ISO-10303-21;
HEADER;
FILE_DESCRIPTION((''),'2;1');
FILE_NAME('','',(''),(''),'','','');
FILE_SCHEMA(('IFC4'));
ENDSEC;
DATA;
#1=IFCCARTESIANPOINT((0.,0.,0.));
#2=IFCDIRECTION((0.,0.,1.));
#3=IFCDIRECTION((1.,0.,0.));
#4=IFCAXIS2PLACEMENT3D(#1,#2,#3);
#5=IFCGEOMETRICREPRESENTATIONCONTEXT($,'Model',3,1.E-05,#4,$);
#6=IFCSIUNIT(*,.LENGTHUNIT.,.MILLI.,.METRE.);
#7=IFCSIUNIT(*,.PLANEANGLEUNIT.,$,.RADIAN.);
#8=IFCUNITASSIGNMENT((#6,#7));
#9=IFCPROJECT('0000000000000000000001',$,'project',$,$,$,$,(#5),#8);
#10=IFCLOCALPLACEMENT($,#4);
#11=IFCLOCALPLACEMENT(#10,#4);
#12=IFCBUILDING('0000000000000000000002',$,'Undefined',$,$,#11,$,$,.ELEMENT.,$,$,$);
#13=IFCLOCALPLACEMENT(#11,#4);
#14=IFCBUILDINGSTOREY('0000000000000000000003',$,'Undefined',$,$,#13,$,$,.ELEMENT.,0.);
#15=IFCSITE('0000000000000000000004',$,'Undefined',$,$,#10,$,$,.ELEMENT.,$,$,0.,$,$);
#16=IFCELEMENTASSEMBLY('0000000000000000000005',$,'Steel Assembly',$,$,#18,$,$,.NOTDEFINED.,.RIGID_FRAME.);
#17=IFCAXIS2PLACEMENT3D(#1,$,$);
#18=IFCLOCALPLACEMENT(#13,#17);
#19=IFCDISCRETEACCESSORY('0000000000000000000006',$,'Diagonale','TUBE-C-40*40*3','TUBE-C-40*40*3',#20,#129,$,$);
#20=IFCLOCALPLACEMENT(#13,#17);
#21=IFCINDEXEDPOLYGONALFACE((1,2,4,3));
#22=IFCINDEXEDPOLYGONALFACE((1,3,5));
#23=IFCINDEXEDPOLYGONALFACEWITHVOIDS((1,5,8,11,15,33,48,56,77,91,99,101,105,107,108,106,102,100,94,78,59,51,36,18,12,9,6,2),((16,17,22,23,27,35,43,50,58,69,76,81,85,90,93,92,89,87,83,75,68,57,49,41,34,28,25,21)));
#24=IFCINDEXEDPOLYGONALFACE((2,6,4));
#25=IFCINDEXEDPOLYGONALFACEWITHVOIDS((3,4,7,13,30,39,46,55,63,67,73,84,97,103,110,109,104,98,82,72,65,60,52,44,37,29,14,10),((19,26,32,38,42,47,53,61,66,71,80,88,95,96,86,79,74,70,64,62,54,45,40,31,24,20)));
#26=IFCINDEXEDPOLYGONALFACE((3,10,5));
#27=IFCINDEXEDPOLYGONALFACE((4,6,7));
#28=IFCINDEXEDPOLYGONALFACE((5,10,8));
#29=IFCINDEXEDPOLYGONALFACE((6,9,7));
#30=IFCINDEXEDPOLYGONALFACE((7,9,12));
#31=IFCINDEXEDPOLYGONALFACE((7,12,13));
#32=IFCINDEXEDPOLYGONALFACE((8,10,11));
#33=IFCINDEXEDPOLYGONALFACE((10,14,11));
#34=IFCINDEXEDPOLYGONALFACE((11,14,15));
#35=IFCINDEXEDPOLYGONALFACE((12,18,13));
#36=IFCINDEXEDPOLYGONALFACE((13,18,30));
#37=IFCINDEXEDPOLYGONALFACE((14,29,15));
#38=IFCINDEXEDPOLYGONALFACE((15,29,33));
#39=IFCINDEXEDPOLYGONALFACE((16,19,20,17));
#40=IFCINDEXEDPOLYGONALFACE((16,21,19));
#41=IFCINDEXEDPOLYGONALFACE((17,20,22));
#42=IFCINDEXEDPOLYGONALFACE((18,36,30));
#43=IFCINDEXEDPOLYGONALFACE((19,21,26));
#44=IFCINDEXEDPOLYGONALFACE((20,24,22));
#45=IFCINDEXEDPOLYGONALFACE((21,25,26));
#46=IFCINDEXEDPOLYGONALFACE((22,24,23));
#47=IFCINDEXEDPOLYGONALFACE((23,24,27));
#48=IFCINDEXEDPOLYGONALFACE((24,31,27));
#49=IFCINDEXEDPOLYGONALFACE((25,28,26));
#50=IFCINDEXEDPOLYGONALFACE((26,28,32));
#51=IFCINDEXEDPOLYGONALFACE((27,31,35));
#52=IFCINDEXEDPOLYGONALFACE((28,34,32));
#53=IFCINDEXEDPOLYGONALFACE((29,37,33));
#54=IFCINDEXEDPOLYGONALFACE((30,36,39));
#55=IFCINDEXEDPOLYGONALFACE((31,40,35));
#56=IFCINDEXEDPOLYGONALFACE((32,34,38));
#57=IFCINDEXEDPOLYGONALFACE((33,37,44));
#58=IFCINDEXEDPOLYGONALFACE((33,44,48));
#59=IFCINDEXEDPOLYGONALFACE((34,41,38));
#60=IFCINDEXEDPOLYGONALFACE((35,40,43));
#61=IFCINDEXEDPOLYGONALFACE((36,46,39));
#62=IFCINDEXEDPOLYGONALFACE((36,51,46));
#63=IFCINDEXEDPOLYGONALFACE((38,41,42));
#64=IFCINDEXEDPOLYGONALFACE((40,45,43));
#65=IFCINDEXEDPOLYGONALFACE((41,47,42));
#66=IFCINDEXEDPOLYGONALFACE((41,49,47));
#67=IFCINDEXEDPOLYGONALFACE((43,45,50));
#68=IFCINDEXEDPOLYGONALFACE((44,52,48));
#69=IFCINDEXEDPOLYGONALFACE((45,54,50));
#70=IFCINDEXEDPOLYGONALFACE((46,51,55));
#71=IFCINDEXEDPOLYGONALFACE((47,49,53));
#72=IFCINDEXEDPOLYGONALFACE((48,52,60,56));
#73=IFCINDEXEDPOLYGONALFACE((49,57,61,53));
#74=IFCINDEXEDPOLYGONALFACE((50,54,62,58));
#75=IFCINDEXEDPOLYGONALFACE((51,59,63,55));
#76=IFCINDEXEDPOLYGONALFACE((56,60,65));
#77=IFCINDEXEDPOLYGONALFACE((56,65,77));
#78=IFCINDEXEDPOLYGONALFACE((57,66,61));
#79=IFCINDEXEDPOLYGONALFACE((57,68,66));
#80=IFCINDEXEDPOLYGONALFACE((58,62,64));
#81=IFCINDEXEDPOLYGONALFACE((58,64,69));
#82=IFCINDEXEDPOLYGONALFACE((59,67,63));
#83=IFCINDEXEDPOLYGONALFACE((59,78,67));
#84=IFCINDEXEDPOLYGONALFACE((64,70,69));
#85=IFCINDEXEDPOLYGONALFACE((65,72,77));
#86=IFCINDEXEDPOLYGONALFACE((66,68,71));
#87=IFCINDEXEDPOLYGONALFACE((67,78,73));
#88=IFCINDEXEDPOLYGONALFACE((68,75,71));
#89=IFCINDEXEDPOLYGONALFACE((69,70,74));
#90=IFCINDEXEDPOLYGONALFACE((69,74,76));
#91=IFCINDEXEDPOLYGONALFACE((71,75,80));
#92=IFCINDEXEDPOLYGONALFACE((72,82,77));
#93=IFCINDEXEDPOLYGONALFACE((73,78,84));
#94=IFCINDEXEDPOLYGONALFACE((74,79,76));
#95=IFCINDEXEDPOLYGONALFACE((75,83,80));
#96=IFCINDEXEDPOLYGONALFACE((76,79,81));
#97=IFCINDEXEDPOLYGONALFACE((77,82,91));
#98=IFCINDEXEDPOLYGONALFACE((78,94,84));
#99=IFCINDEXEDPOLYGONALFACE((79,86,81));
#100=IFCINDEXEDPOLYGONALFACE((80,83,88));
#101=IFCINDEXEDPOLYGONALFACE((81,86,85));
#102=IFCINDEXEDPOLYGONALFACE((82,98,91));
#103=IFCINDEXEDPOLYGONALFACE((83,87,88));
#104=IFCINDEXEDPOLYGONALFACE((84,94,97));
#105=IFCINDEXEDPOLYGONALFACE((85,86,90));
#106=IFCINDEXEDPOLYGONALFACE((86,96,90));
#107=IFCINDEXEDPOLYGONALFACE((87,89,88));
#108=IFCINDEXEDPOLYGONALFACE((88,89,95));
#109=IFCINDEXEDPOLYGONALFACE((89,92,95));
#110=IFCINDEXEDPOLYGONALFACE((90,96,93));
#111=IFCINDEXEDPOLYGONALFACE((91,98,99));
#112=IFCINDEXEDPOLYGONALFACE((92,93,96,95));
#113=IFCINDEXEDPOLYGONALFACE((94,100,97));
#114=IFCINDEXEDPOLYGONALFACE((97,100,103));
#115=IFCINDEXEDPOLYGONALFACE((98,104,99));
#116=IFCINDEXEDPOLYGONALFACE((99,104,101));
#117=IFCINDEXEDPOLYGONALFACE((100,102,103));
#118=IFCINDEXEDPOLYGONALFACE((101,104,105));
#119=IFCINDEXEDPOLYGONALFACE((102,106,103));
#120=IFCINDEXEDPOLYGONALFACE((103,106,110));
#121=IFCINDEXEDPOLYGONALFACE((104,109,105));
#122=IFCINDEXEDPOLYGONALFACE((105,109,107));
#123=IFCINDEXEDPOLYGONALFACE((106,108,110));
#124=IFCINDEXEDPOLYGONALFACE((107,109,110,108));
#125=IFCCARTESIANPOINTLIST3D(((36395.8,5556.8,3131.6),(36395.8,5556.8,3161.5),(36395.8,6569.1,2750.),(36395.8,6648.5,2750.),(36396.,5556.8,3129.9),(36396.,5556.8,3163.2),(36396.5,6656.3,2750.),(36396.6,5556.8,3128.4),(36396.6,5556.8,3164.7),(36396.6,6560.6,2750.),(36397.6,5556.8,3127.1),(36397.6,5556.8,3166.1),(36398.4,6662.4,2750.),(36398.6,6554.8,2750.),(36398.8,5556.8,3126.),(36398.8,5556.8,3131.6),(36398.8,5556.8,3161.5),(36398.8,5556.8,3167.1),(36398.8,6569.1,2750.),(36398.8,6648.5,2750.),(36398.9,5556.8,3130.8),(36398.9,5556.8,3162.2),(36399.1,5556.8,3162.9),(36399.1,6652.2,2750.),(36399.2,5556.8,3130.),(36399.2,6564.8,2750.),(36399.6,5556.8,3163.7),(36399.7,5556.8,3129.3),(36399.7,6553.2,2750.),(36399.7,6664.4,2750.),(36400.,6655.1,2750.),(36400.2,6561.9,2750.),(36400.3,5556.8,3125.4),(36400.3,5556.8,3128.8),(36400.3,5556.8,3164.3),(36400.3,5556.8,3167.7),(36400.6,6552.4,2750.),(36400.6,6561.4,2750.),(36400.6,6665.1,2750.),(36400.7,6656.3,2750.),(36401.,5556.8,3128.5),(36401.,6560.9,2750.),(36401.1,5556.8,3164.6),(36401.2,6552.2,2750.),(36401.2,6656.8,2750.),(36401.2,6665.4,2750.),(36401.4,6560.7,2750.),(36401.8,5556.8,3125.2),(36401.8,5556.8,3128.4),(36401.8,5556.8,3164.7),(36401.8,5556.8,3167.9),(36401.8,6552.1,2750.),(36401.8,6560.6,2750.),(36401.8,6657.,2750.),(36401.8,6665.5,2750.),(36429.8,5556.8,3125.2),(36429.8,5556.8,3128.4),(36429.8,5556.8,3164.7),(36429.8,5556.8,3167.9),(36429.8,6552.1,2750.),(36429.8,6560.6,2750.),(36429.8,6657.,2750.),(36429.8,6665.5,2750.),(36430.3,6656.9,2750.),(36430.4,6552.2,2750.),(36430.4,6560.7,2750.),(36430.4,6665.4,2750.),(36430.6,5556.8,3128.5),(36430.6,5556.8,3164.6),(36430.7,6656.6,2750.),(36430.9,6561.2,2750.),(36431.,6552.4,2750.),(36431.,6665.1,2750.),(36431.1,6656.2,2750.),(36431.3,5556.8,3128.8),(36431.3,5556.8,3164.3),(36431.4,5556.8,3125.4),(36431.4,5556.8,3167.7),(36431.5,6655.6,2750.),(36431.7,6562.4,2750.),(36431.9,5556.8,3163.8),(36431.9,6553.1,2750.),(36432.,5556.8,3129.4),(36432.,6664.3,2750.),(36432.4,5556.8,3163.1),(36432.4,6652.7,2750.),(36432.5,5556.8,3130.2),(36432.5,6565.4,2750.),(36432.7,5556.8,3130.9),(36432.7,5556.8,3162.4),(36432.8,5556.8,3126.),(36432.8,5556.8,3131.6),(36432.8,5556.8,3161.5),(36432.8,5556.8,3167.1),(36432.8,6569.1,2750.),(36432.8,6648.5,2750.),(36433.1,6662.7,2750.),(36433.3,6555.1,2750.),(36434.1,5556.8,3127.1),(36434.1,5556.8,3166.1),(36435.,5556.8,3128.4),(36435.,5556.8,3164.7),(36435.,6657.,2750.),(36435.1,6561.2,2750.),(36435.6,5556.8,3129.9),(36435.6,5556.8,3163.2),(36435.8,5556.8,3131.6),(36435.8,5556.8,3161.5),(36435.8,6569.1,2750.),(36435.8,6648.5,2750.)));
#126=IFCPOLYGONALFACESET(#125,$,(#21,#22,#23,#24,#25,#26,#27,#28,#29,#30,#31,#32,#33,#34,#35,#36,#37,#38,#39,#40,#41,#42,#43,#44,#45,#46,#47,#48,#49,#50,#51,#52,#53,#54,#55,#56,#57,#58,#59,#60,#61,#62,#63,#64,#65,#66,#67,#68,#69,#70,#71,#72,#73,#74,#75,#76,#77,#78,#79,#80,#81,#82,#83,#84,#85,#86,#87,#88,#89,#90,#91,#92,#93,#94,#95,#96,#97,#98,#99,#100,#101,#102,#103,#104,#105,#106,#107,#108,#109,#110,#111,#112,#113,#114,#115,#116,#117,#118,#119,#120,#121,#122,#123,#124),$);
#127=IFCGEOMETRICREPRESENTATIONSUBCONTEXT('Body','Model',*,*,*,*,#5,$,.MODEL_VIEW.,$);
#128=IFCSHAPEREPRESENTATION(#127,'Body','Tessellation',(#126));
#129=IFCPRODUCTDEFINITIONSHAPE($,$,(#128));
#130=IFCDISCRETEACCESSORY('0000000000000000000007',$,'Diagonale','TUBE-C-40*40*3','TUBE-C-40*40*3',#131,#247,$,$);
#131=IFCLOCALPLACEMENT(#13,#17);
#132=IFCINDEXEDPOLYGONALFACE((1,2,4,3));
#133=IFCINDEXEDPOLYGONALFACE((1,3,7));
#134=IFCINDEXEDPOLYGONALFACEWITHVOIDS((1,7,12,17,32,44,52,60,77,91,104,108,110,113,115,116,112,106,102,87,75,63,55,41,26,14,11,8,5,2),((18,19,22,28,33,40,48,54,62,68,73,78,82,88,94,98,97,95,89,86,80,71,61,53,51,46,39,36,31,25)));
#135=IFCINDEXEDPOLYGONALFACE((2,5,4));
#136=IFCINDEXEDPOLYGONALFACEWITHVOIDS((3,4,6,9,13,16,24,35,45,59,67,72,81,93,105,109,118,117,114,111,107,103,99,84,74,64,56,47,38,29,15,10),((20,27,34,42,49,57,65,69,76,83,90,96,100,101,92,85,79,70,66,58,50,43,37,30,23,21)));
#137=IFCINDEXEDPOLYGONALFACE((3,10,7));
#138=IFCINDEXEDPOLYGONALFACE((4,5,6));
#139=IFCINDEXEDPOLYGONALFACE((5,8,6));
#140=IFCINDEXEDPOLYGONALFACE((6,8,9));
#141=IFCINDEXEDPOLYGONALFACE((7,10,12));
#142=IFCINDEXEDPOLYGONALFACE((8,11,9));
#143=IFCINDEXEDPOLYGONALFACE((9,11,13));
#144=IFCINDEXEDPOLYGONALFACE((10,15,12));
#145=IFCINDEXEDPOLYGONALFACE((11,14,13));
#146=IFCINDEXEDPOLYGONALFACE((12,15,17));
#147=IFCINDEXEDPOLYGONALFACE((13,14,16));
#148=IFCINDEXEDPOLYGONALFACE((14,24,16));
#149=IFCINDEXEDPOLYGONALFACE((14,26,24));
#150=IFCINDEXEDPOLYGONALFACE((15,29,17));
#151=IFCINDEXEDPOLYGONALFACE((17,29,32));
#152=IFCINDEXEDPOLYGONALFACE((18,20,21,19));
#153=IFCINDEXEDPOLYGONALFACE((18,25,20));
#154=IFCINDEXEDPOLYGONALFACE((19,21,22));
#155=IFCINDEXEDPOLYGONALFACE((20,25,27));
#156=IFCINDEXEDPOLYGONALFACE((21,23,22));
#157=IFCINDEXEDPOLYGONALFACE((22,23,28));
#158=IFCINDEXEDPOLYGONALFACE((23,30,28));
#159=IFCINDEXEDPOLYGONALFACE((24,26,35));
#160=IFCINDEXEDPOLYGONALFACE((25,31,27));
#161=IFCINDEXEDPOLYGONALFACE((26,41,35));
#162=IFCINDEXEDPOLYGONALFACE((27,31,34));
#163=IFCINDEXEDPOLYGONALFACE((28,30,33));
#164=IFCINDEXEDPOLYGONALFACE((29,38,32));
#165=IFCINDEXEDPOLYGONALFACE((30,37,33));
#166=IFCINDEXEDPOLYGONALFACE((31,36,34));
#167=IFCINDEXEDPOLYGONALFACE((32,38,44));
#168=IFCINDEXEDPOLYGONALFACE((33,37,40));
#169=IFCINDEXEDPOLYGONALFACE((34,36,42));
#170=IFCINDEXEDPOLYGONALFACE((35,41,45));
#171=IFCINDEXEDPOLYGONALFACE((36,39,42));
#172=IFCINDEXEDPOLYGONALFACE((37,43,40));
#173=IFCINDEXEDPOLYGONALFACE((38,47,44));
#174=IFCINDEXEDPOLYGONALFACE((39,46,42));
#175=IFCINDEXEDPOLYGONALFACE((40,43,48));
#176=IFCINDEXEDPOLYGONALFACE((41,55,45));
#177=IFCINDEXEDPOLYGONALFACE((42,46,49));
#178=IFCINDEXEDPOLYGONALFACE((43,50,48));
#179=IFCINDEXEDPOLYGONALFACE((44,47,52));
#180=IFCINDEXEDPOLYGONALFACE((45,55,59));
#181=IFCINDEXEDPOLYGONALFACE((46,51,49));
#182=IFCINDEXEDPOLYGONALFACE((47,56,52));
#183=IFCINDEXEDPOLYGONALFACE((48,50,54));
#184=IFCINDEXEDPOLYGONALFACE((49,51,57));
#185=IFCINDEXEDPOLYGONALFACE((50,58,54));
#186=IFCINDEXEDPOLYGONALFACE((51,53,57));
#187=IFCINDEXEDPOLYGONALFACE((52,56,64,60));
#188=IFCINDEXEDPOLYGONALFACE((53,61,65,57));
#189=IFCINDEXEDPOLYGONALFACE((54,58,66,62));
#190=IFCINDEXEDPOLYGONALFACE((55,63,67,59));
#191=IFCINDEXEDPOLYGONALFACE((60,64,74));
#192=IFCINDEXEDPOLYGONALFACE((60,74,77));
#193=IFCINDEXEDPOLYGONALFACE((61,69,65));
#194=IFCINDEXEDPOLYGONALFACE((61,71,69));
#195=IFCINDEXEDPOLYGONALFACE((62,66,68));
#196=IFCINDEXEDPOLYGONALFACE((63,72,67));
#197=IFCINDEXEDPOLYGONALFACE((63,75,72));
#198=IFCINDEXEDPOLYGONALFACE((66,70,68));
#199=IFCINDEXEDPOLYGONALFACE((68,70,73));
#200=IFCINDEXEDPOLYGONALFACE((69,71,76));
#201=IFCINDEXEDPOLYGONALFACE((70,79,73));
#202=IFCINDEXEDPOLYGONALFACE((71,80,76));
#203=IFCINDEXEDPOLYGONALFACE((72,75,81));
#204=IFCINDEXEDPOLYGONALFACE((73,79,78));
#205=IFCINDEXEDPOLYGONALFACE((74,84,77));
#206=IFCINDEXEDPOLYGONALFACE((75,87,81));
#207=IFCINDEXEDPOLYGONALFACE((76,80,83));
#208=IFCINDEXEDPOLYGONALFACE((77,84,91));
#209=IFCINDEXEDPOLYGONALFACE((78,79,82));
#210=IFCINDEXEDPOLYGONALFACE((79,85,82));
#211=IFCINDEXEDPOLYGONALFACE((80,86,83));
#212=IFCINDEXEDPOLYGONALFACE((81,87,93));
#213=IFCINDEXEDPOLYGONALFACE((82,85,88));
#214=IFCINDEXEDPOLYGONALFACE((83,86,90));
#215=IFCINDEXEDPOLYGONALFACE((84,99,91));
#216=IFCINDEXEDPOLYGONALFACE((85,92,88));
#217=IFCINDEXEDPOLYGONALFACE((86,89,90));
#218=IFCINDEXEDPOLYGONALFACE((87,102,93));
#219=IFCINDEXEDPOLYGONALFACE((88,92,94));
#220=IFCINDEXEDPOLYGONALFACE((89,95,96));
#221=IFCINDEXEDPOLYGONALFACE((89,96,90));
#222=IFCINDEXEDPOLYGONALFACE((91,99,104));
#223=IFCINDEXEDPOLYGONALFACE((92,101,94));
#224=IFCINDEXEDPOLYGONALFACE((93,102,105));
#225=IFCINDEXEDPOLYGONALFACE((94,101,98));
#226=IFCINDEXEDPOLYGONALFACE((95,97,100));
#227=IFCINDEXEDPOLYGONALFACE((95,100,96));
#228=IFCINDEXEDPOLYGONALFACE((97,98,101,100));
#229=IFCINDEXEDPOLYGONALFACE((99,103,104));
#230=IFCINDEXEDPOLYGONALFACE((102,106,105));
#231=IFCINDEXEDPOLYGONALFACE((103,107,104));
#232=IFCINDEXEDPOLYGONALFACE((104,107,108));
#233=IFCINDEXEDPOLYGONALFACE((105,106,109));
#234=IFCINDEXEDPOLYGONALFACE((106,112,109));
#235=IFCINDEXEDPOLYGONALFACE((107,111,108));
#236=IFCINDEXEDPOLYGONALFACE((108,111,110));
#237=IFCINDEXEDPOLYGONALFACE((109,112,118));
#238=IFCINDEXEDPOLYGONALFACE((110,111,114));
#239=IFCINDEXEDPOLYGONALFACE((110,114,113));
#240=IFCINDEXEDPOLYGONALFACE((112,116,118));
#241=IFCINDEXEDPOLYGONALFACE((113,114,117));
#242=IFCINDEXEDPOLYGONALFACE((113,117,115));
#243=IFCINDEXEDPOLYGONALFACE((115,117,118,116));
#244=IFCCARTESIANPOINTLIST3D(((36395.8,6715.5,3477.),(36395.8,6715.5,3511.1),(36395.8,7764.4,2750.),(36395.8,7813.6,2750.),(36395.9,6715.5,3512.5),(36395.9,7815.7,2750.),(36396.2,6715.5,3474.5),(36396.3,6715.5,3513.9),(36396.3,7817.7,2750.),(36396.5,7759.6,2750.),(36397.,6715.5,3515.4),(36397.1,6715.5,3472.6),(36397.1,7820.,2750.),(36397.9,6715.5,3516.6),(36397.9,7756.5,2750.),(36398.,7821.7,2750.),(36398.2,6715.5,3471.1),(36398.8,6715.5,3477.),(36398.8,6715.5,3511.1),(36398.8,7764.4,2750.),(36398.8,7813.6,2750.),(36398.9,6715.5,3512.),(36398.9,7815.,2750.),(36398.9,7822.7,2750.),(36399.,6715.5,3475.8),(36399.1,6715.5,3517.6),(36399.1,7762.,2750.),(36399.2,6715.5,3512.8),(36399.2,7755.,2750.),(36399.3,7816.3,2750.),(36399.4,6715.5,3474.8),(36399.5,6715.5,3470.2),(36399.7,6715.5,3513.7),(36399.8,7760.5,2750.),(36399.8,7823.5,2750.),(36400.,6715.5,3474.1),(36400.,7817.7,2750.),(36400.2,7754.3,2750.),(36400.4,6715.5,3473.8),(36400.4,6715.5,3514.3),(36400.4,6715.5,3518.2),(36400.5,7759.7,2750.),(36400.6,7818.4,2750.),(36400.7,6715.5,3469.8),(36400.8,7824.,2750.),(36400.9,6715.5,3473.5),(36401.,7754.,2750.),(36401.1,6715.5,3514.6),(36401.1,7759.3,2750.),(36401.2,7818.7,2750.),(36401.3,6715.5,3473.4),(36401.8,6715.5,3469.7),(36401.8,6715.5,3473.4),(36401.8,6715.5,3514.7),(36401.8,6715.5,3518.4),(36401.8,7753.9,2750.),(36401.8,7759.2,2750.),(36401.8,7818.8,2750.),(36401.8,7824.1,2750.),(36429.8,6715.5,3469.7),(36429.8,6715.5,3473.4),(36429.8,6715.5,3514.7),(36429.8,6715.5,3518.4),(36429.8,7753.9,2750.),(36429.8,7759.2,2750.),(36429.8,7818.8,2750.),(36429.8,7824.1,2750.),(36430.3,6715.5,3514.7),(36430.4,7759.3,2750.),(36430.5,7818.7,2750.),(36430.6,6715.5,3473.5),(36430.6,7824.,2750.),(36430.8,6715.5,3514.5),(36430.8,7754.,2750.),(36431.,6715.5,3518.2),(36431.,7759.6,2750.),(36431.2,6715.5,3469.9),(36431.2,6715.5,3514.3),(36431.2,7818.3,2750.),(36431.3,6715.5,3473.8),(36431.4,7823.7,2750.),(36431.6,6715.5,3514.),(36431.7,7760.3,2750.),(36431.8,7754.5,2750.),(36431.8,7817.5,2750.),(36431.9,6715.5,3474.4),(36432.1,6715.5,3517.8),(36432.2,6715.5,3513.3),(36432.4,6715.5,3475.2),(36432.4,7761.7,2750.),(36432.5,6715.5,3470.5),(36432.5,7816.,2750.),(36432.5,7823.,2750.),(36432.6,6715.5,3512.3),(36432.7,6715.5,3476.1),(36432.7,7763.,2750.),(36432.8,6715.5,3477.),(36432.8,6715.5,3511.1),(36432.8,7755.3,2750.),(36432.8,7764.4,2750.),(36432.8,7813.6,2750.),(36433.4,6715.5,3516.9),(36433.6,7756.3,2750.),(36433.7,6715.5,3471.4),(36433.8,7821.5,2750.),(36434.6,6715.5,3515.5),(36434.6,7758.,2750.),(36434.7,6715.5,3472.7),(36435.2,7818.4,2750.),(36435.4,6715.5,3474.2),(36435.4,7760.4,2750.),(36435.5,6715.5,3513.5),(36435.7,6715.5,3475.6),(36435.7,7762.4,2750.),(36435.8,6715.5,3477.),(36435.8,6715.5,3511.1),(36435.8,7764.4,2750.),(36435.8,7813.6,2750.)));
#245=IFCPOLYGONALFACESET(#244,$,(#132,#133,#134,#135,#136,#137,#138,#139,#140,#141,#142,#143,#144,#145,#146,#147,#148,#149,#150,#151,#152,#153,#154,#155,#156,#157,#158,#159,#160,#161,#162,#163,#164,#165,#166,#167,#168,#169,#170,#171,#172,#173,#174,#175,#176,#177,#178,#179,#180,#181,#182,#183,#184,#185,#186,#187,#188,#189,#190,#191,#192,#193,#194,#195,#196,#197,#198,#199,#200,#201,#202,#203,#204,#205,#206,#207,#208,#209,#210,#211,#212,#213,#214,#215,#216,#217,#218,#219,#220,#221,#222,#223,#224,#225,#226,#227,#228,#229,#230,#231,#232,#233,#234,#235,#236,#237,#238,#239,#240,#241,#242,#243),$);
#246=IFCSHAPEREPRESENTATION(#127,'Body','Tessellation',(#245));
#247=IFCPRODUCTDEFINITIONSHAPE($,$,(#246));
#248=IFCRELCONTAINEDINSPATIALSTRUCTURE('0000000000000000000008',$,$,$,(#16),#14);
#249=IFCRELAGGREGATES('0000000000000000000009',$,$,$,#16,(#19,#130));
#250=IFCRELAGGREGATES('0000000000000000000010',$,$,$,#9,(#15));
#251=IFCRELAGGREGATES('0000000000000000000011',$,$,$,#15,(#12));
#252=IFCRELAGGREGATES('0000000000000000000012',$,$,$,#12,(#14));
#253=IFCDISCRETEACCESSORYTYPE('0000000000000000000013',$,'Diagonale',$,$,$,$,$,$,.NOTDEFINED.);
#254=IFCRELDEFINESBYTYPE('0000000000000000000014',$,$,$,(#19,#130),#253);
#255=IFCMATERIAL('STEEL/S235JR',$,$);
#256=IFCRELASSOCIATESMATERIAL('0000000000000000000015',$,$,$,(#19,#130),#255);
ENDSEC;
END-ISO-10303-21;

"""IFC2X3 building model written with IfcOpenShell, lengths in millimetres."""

from ifc_helpers import new_model, si_unit, frame, origin_with_axes, origin_2d_with_axis, place, context, subcontext, project, spatial, hollow_rectangle, extrude, clip, halfspace, material, type_object, element, aggregate, save


model = new_model("IFC2X3")

# Units and contexts
model_context = context("Model", 3, precision=1e-05, world=origin_with_axes())
body_context = subcontext(model_context, "Body", "Model", "MODEL_VIEW")
ifc_project = project(units=[si_unit("LENGTHUNIT", "METRE", prefix="MILLI"), si_unit("PLANEANGLEUNIT", "RADIAN")], contexts=[model_context])

# Site, building, storey
site_placement = place(None, origin_with_axes())
site = spatial("IfcSite", under=ifc_project, at=site_placement, Name="Undefined", CompositionType="ELEMENT", RefElevation=0.0)
building_placement = place(site_placement, origin_with_axes())
building = spatial("IfcBuilding", under=site, at=building_placement, Name="Undefined", CompositionType="ELEMENT")
storey_placement = place(building_placement, origin_with_axes())
storey = spatial("IfcBuildingStorey", under=building, at=storey_placement, Name="Undefined", CompositionType="ELEMENT", Elevation=0.0)

# Shared definitions
ifc_material_1 = material(Name="STEEL/S235JR")

# Element assembly, discrete accessories
assembly_1_placement = place(storey_placement, origin_with_axes())
assembly_1 = element("IfcElementAssembly", 1, at=assembly_1_placement, inside=storey, Name="Steel Assembly", AssemblyPlace="NOTDEFINED", PredefinedType="RIGID_FRAME")
discrete_accessory_type_1 = type_object("IfcDiscreteAccessoryType", Name="Diagonale")
discrete_accessory_1_placement = place(assembly_1_placement, frame((36415.8, 6658.4, 2731.3), z_axis=(0.0, 0.352745, 0.93572), x_axis=(0.0, -0.93572, 0.352745)))
discrete_accessory_1 = element("IfcDiscreteAccessory", 2, at=discrete_accessory_1_placement, type_object=discrete_accessory_type_1, material=ifc_material_1, Name="Diagonale", Description="TUBE-C-40*40*3", ObjectType="TUBE-C-40*40*3", context=body_context, shape_type="Clipping", body=[
    clip(clip(extrude(hollow_rectangle(XDim=40.0, YDim=40.0, WallThickness=3.0, InnerFilletRadius=3.0, OuterFilletRadius=6.0, at=origin_2d_with_axis()), frame((1238.5, 0.0, 0.0), z_axis=(-1.0, 0.0, 0.0), x_axis=(0.0, -1.0, 0.0)), (0.0, 0.0, 1.0), 1246.6), halfspace(frame((1146.9, 0.0, -80.5), z_axis=(0.93572, 0.0, -0.352745), x_axis=(0.352745, 0.0, 0.93572)), False)), halfspace(frame((172.4, 0.0, -45.0), z_axis=(0.352745, 0.0, 0.93572), x_axis=(-0.93572, 0.0, 0.352745)), True)),
])
discrete_accessory_2_placement = place(assembly_1_placement, frame((36415.8, 7812.7, 2733.6), z_axis=(0.0, 0.569631, 0.821901), x_axis=(0.0, -0.821901, 0.569631)))
discrete_accessory_2 = element("IfcDiscreteAccessory", 3, at=discrete_accessory_2_placement, type_object=discrete_accessory_type_1, material=ifc_material_1, Name="Diagonale", Description="TUBE-C-40*40*3", ObjectType="TUBE-C-40*40*3", context=body_context, shape_type="Clipping", body=[
    clip(clip(extrude(hollow_rectangle(XDim=40.0, YDim=40.0, WallThickness=3.0, InnerFilletRadius=3.0, OuterFilletRadius=6.0, at=origin_2d_with_axis()), frame((1378.2, 0.0, 0.0), z_axis=(-1.0, 0.0, 0.0), x_axis=(0.0, -1.0, 0.0)), (0.0, 0.0, 1.0), 1392.5), halfspace(frame((1298.5, 0.0, -52.7), z_axis=(0.821901, 0.0, -0.569631), x_axis=(0.569631, 0.0, 0.821901)), False)), halfspace(frame((80.9, 0.0, -36.0), z_axis=(0.569631, 0.0, 0.821901), x_axis=(-0.821901, 0.0, 0.569631)), True)),
])
aggregate(assembly_1, [discrete_accessory_1, discrete_accessory_2])

save(model, "model.ifc")
